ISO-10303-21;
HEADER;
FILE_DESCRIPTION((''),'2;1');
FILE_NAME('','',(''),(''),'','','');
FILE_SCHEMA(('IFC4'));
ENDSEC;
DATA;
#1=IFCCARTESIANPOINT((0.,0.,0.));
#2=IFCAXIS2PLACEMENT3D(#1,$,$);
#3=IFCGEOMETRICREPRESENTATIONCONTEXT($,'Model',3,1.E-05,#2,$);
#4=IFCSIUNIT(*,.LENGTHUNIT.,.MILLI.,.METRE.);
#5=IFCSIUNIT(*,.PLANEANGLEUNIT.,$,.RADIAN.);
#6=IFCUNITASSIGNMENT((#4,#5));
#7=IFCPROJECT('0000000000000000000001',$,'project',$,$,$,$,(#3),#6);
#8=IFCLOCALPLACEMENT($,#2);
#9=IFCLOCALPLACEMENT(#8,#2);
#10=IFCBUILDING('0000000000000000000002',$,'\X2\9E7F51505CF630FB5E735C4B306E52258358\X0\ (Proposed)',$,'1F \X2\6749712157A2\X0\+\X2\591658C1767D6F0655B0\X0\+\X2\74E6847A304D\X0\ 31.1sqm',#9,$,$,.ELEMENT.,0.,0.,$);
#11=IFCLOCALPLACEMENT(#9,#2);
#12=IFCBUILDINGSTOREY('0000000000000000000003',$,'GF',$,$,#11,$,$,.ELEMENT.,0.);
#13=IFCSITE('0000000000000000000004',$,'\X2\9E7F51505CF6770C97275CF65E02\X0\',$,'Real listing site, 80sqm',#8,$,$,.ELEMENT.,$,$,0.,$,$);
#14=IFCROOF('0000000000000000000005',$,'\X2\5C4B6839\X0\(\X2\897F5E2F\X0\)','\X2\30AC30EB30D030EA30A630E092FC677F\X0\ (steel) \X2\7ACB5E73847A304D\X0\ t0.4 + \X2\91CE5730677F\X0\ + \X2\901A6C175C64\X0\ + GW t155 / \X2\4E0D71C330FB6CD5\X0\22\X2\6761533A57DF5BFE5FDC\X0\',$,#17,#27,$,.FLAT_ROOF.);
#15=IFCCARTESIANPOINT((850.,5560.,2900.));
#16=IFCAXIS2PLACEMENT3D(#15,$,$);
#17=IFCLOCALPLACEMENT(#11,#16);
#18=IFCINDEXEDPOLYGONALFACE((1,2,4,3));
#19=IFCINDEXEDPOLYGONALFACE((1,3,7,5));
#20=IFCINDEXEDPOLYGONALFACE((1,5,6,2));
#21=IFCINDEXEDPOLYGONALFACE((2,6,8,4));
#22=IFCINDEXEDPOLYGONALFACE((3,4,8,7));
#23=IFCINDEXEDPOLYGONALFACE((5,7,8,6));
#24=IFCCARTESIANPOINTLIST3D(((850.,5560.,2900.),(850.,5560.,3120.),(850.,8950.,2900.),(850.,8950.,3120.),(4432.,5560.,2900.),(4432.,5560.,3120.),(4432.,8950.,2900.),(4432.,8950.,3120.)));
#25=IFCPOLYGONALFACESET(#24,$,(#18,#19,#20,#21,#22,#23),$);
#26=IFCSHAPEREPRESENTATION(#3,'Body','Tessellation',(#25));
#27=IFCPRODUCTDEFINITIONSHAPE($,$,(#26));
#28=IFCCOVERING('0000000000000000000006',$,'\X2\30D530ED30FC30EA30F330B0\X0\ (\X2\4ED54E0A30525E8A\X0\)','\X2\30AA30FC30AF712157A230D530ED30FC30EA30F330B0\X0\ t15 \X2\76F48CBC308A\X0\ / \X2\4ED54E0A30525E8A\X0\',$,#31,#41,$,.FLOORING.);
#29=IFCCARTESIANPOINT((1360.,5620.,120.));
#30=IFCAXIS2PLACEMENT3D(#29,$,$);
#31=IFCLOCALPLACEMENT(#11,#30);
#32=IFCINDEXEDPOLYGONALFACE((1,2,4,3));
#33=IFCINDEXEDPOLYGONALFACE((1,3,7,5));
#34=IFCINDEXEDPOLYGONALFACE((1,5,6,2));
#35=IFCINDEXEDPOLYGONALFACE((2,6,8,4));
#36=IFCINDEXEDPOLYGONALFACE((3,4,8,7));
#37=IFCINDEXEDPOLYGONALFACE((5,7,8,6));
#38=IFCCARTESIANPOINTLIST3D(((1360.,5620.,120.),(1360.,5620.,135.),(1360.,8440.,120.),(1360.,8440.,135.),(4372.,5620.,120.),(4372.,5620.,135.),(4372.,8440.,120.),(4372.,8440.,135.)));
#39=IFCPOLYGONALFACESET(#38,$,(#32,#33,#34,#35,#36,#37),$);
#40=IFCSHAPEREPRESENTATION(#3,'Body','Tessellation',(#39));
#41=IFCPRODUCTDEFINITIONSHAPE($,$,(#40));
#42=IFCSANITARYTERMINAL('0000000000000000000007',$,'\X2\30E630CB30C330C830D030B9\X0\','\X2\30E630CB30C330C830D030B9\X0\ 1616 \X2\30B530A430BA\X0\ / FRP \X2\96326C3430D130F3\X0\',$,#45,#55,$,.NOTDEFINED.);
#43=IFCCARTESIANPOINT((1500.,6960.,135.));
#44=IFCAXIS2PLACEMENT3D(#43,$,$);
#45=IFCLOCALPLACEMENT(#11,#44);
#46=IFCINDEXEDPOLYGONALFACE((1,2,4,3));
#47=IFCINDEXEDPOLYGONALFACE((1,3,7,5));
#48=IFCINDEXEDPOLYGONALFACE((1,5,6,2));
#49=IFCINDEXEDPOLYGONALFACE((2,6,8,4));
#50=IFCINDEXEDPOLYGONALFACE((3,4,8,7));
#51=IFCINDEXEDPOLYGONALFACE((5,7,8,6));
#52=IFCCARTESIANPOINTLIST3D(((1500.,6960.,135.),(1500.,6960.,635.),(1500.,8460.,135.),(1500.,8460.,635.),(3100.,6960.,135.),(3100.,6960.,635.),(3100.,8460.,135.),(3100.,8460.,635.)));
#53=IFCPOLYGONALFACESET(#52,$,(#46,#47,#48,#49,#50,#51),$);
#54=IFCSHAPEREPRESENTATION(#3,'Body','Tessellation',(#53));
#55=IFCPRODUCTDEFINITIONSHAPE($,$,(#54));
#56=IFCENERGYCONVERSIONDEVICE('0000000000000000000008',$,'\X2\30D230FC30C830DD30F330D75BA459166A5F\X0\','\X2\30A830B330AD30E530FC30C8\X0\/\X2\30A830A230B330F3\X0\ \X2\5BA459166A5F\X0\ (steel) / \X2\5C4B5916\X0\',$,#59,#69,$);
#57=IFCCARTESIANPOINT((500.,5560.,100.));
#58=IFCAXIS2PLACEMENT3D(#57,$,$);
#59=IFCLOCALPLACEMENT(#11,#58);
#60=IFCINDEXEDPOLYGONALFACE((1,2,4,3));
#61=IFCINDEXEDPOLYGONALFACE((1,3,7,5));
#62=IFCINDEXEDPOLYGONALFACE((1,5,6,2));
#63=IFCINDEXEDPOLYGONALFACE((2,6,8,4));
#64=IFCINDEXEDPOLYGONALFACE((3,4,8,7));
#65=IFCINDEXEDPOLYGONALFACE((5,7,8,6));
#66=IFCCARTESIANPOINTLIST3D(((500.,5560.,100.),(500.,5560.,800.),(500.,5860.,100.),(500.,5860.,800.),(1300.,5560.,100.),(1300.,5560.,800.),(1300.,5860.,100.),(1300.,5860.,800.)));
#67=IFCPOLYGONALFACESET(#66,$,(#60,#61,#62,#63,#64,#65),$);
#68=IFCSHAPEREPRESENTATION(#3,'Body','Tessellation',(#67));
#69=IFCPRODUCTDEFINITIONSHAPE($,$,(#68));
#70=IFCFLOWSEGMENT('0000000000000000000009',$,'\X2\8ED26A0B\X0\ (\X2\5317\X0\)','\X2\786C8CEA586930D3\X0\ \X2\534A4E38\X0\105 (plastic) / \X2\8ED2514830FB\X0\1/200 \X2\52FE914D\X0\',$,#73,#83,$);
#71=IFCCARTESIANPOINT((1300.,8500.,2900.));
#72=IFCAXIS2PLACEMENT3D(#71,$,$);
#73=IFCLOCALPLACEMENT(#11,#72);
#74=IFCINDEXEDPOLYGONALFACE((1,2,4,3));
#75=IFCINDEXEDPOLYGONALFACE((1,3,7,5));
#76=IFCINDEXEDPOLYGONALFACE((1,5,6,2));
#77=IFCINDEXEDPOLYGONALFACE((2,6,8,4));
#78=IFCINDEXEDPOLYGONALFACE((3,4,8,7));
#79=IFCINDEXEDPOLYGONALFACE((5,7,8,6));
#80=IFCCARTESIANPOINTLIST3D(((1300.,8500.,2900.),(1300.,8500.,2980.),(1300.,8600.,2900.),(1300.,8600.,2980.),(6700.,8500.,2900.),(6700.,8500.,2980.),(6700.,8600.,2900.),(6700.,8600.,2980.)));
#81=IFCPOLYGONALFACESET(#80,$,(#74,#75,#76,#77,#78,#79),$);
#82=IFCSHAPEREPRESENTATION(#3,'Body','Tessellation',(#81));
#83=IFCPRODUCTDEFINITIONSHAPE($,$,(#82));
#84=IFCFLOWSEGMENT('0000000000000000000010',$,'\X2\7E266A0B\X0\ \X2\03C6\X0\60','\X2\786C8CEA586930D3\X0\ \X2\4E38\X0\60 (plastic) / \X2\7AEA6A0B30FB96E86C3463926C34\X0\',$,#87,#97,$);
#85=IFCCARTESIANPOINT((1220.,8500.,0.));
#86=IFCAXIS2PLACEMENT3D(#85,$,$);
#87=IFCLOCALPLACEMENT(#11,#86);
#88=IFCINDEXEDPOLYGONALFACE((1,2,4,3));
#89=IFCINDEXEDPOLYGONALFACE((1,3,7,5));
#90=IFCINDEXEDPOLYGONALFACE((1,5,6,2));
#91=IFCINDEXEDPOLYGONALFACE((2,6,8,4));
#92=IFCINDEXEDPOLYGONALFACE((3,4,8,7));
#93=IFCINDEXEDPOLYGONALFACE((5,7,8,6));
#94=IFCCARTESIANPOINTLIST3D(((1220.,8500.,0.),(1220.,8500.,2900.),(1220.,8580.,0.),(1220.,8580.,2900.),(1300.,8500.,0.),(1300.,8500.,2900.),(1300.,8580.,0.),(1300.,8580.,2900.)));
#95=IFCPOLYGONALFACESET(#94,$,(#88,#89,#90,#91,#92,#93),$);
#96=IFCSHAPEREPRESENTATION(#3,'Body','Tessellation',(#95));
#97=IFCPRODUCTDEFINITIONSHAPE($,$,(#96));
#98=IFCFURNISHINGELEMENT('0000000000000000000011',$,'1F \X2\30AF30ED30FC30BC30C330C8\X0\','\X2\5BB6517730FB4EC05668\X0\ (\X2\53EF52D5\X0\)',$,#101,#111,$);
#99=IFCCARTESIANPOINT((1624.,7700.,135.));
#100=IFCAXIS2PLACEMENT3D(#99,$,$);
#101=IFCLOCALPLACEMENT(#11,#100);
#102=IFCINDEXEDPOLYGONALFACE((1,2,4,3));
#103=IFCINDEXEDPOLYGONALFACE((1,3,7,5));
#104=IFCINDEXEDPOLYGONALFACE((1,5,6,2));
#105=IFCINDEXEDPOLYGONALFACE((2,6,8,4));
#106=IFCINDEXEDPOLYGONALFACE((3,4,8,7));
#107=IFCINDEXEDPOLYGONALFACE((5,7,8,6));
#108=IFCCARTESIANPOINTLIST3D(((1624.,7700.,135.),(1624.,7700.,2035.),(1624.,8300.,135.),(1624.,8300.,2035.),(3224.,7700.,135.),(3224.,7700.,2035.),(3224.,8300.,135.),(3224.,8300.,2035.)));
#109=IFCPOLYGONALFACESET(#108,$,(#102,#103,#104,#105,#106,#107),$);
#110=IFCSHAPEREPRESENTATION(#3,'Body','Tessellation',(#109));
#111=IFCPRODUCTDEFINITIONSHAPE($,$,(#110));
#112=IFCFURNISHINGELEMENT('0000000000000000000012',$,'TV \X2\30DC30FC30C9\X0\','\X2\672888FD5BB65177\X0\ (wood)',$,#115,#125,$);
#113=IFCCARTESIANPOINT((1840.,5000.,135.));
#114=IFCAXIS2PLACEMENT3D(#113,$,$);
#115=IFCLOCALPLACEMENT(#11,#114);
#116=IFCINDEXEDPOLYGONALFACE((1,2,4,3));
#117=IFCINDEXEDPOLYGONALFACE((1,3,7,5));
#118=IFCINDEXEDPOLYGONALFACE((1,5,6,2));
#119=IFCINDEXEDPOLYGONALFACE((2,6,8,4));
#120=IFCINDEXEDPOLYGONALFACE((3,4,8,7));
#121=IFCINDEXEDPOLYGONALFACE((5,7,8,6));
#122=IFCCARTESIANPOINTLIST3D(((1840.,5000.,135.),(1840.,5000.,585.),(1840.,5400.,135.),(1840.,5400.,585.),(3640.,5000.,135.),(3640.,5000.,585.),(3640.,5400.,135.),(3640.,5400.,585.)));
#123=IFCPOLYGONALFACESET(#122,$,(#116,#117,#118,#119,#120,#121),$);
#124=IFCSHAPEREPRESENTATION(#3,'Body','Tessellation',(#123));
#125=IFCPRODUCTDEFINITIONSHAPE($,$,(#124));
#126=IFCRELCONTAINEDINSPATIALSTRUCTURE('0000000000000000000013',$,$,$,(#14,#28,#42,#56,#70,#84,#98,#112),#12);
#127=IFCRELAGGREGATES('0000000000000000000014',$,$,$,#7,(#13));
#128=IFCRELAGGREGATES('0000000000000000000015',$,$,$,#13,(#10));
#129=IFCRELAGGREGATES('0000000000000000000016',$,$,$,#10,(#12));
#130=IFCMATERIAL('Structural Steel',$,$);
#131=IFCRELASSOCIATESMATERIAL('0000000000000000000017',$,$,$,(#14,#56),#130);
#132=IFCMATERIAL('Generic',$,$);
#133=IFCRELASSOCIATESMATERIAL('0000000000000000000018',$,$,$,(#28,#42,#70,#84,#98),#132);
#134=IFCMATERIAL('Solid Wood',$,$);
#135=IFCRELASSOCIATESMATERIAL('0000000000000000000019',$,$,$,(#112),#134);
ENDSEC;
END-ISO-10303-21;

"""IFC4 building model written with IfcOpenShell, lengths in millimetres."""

from ifc_helpers import new_model, si_unit, frame, frame_2d, origin, place, context, project, spatial, rectangle, extrude, material, element, save


model = new_model("IFC4")

# Units and contexts
model_context = context("Model", 3, precision=1e-05, world=origin())
ifc_project = project(units=[si_unit("LENGTHUNIT", "METRE", prefix="MILLI"), si_unit("PLANEANGLEUNIT", "RADIAN")], contexts=[model_context])

# Site, building, storey
site_placement = place(None, origin())
site = spatial("IfcSite", under=ifc_project, at=site_placement, Name="鹿児島県霧島市", ObjectType="Real listing site, 80sqm", CompositionType="ELEMENT", RefElevation=0.0)
building_placement = place(site_placement, origin())
building = spatial("IfcBuilding", under=site, at=building_placement, Name="鹿児島・平屋の別荘 (Proposed)", ObjectType="1F 杉無垢+外壁白漆喰+瓦葺き 31.1sqm", CompositionType="ELEMENT", ElevationOfRefHeight=0.0, ElevationOfTerrain=0.0)
storey_placement = place(building_placement, origin())
storey = spatial("IfcBuildingStorey", under=building, at=storey_placement, Name="GF", CompositionType="ELEMENT", Elevation=0.0)

# Shared definitions
ifc_material_1 = material(Name="Solid Wood")

# Roof
ifc_material_2 = material(Name="Structural Steel")
roof_placement = place(storey_placement, frame((850.0, 5560.0, 2900.0)))
element("IfcRoof", 1, at=roof_placement, inside=storey, material=ifc_material_2, Name="屋根(西帯)", Description="ガルバリウム鋼板 (steel) 立平葺き t0.4 + 野地板 + 通気層 + GW t155 / 不燃・法22条区域対応", PredefinedType="FLAT_ROOF", context=model_context, shape_type="SweptSolid", body=[
    extrude(rectangle(XDim=3582.0, YDim=3390.0, at=frame_2d((1791.0, 1695.0))), frame((850.0, 5560.0, 2900.0)), (0.0, 0.0, 1.0), 220.0),
])

# Covering
ifc_material_3 = material(Name="Generic")
covering_placement = place(storey_placement, frame((1360.0, 5620.0, 120.0)))
element("IfcCovering", 2, at=covering_placement, inside=storey, material=ifc_material_3, Name="フローリング (仕上げ床)", Description="オーク無垢フローリング t15 直貼り / 仕上げ床", PredefinedType="FLOORING", context=model_context, shape_type="SweptSolid", body=[
    extrude(rectangle(XDim=3012.0, YDim=2820.0, at=frame_2d((1506.0, 1410.0))), frame((1360.0, 5620.0, 120.0)), (0.0, 0.0, 1.0), 15.0),
])

# Sanitary terminal
sanitary_terminal_placement = place(storey_placement, frame((1500.0, 6960.0, 135.0)))
element("IfcSanitaryTerminal", 3, at=sanitary_terminal_placement, inside=storey, material=ifc_material_3, Name="ユニットバス", Description="ユニットバス 1616 サイズ / FRP 防水パン", PredefinedType="NOTDEFINED", context=model_context, shape_type="SweptSolid", body=[
    extrude(rectangle(XDim=1600.0, YDim=1500.0, at=frame_2d((800.0, 750.0))), frame((1500.0, 6960.0, 135.0)), (0.0, 0.0, 1.0), 500.0),
])

# Energy conversion device
energy_conversion_device_placement = place(storey_placement, frame((500.0, 5560.0, 100.0)))
element("IfcEnergyConversionDevice", 4, at=energy_conversion_device_placement, inside=storey, material=ifc_material_2, Name="ヒートポンプ室外機", Description="エコキュート/エアコン 室外機 (steel) / 屋外", context=model_context, shape_type="SweptSolid", body=[
    extrude(rectangle(XDim=800.0, YDim=300.0, at=frame_2d((400.0, 150.0))), frame((500.0, 5560.0, 100.0)), (0.0, 0.0, 1.0), 700.0),
])

# Flow segments
flow_segment_1_placement = place(storey_placement, frame((1300.0, 8500.0, 2900.0)))
element("IfcFlowSegment", 5, at=flow_segment_1_placement, inside=storey, material=ifc_material_3, Name="軒樋 (北)", Description="硬質塩ビ 半丸105 (plastic) / 軒先・1/200 勾配", context=model_context, shape_type="SweptSolid", body=[
    extrude(rectangle(XDim=5400.0, YDim=100.0, at=frame_2d((2700.0, 50.0))), frame((1300.0, 8500.0, 2900.0)), (0.0, 0.0, 1.0), 80.0),
])
flow_segment_2_placement = place(storey_placement, frame((1220.0, 8500.0, 0.0)))
element("IfcFlowSegment", 6, at=flow_segment_2_placement, inside=storey, material=ifc_material_3, Name="縦樋 φ60", Description="硬質塩ビ 丸60 (plastic) / 竪樋・雨水排水", context=model_context, shape_type="SweptSolid", body=[
    extrude(rectangle(XDim=80.0, YDim=80.0, at=frame_2d((40.0, 40.0))), frame((1220.0, 8500.0, 0.0)), (0.0, 0.0, 1.0), 2900.0),
])

# Furnishing elements
furnishing_1_placement = place(storey_placement, frame((1624.0, 7700.0, 135.0)))
element("IfcFurnishingElement", 7, at=furnishing_1_placement, inside=storey, material=ifc_material_3, Name="1F クローゼット", Description="家具・什器 (可動)", context=model_context, shape_type="SweptSolid", body=[
    extrude(rectangle(XDim=1600.0, YDim=600.0, at=frame_2d((800.0, 300.0))), frame((1624.0, 7700.0, 135.0)), (0.0, 0.0, 1.0), 1900.0),
])
furnishing_2_placement = place(storey_placement, frame((1840.0, 5000.0, 135.0)))
element("IfcFurnishingElement", 8, at=furnishing_2_placement, inside=storey, material=ifc_material_1, Name="TV ボード", Description="木製家具 (wood)", context=model_context, shape_type="SweptSolid", body=[
    extrude(rectangle(XDim=1800.0, YDim=400.0, at=frame_2d((900.0, 200.0))), frame((1840.0, 5000.0, 135.0)), (0.0, 0.0, 1.0), 450.0),
])

save(model, "model.ifc")
